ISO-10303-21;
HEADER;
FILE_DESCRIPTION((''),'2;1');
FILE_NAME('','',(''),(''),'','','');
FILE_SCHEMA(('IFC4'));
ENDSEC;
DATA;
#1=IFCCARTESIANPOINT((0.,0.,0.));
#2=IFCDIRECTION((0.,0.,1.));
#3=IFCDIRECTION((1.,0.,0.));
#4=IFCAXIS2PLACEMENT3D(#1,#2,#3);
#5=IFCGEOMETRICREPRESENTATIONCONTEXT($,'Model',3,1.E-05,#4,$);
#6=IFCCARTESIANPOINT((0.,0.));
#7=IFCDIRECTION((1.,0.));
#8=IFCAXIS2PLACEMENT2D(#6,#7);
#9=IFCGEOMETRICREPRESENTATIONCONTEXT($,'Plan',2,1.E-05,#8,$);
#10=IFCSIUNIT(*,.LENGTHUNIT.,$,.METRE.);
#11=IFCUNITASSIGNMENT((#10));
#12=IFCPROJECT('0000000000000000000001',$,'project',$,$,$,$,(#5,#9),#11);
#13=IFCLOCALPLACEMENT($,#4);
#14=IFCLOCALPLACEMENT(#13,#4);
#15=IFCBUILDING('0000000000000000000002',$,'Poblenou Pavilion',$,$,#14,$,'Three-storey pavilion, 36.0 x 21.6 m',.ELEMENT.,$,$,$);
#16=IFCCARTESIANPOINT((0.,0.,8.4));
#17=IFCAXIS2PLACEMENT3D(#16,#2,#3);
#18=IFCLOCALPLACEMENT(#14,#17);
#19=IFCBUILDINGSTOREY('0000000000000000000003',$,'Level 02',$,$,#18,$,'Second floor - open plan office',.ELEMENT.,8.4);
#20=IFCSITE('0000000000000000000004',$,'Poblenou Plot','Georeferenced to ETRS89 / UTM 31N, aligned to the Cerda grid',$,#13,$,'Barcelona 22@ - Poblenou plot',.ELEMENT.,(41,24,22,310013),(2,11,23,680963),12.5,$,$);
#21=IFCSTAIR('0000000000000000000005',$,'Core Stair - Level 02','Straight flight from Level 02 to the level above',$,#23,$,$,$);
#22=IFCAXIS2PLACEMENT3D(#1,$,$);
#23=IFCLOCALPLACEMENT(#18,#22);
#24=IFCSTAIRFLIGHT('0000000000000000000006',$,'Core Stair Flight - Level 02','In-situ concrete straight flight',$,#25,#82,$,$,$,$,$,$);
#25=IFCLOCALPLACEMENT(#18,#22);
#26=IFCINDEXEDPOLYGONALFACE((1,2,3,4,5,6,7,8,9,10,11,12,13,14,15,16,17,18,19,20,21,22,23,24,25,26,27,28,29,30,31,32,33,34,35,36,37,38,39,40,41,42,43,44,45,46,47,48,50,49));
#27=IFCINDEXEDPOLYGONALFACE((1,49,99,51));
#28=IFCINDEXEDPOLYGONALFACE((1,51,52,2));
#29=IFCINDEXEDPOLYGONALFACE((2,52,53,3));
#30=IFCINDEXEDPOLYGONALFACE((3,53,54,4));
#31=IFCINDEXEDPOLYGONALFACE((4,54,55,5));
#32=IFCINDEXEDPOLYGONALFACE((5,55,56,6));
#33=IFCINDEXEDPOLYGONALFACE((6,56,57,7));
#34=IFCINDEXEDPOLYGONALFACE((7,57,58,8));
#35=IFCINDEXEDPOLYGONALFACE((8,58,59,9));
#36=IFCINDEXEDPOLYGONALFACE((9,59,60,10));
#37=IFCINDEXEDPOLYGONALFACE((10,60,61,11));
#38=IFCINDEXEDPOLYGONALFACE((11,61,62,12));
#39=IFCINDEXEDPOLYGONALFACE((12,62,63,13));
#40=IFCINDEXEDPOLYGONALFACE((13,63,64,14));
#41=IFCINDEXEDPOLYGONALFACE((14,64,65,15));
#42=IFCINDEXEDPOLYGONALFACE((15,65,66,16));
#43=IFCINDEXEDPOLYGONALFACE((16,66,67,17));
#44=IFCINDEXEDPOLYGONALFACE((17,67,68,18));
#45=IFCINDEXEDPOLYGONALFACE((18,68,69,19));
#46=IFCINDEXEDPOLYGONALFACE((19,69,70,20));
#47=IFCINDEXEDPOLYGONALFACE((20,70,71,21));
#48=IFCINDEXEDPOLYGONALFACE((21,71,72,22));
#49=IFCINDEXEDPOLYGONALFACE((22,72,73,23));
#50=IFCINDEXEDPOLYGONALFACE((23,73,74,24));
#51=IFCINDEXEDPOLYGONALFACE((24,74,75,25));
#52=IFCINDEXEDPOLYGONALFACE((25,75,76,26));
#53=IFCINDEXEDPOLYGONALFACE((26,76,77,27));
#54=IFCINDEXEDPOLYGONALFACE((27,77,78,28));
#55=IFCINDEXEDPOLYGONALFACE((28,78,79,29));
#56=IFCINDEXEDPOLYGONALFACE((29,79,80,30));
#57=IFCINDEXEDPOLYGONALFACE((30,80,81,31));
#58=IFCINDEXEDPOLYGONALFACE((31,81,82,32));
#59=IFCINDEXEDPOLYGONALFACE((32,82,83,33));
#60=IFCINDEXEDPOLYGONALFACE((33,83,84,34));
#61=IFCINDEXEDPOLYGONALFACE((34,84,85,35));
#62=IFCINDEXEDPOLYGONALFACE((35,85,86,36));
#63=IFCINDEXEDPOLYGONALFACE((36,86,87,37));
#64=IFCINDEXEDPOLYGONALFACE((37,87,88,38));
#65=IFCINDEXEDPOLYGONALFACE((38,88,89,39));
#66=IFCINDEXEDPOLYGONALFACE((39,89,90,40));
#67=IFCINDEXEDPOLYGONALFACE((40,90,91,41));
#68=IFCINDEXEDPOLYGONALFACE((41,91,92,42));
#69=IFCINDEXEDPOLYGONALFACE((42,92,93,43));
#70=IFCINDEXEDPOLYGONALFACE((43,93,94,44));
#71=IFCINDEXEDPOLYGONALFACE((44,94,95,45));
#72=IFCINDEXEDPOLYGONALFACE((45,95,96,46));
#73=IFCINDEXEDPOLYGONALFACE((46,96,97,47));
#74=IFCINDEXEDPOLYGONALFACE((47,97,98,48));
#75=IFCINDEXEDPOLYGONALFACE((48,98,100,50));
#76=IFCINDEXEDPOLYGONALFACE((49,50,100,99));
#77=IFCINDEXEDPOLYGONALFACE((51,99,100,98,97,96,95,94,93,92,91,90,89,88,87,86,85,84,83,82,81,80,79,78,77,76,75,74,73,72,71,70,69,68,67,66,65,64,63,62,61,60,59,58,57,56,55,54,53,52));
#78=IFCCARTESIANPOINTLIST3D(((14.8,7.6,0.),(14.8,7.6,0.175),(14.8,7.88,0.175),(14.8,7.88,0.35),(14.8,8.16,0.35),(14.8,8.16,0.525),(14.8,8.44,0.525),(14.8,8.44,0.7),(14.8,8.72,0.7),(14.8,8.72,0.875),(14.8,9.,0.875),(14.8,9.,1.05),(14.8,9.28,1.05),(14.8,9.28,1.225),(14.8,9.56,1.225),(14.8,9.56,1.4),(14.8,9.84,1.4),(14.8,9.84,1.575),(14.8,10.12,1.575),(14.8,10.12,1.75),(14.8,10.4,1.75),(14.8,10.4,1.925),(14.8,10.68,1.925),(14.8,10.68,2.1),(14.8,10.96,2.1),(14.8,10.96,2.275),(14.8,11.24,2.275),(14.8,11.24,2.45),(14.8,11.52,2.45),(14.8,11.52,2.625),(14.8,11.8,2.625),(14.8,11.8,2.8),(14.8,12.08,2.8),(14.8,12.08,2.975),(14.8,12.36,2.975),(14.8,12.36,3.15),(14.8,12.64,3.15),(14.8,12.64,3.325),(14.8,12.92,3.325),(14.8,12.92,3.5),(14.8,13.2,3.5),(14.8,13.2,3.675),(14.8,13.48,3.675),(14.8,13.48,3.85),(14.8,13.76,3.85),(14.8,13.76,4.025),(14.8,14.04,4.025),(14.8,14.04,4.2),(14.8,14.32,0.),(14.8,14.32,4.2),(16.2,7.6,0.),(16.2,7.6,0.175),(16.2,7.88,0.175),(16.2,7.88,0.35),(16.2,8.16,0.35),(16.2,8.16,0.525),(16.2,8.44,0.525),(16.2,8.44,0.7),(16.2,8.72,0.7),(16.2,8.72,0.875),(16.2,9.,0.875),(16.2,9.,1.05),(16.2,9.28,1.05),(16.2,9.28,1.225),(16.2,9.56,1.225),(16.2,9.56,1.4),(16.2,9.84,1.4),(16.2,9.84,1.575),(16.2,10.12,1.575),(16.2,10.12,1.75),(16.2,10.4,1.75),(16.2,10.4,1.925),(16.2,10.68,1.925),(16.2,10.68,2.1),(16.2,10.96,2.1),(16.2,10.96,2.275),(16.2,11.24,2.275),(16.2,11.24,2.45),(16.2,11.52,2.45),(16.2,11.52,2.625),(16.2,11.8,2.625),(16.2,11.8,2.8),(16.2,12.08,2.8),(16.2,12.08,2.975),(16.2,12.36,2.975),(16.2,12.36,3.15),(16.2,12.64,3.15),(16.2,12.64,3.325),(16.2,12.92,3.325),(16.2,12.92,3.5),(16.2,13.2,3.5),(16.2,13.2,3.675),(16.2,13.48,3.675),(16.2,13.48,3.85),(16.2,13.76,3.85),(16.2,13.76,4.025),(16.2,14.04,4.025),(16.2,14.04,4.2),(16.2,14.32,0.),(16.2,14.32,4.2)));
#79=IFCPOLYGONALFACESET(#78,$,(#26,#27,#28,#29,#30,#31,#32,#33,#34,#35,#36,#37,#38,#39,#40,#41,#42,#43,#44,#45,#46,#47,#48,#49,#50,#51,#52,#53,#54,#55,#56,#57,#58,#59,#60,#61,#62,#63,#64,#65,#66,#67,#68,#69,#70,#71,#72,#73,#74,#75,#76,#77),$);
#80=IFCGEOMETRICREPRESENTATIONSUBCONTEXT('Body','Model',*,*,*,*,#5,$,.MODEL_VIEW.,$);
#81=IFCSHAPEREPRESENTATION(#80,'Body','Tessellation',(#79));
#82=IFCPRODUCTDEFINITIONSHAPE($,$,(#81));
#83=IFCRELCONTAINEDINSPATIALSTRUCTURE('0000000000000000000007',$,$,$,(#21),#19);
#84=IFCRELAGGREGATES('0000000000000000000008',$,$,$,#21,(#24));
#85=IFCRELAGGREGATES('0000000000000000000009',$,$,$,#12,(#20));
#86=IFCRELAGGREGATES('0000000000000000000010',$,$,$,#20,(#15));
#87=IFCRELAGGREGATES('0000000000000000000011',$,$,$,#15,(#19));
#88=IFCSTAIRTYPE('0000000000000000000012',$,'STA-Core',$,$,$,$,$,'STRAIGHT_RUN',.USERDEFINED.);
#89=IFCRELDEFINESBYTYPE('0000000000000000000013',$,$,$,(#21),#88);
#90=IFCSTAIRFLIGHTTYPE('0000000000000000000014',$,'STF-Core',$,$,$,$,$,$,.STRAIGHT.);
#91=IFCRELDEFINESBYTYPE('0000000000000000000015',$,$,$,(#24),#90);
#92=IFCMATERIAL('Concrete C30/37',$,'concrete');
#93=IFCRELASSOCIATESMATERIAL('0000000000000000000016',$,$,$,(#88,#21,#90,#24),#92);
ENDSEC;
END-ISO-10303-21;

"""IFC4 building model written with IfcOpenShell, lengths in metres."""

from ifc_helpers import new_model, si_unit, frame, origin_with_axes, origin_2d_with_axis, place, context, subcontext, project, spatial, line, indexed_curve, outline, extrude, material, type_object, element, aggregate, save


model = new_model("IFC4")

# Units and contexts
model_context = context("Model", 3, precision=1e-05, world=origin_with_axes())
plan_context = context("Plan", 2, precision=1e-05, world=origin_2d_with_axis())
body_context = subcontext(model_context, "Body", "Model", "MODEL_VIEW")
ifc_project = project(units=[si_unit("LENGTHUNIT", "METRE")], contexts=[model_context, plan_context])

# Site, building, storey
site_placement = place(None, origin_with_axes())
site = spatial("IfcSite", under=ifc_project, at=site_placement, Name="Poblenou Plot", Description="Georeferenced to ETRS89 / UTM 31N, aligned to the Cerda grid", LongName="Barcelona 22@ - Poblenou plot", CompositionType="ELEMENT", RefLatitude=(41, 24, 22, 310013), RefLongitude=(2, 11, 23, 680963), RefElevation=12.5)
building_placement = place(site_placement, origin_with_axes())
building = spatial("IfcBuilding", under=site, at=building_placement, Name="Poblenou Pavilion", LongName="Three-storey pavilion, 36.0 x 21.6 m", CompositionType="ELEMENT")
storey_placement = place(building_placement, frame((0.0, 0.0, 8.4), z_axis=(0.0, 0.0, 1.0), x_axis=(1.0, 0.0, 0.0)))
storey = spatial("IfcBuildingStorey", under=building, at=storey_placement, Name="Level 02", LongName="Second floor - open plan office", CompositionType="ELEMENT", Elevation=8.4)

# Stair, stair flight
ifc_material_1 = material(Name="Concrete C30/37", Category="concrete")
stair_type = type_object("IfcStairType", Name="STA-Core", ElementType="STRAIGHT_RUN", PredefinedType="USERDEFINED", material=ifc_material_1)
stair_placement = place(storey_placement, frame((14.8, 7.6, 0.0), z_axis=(0.0, 0.0, 1.0), x_axis=(1.0, 0.0, 0.0)))
stair = element("IfcStair", 1, at=stair_placement, inside=storey, type_object=stair_type, material=ifc_material_1, Name="Core Stair - Level 02", Description="Straight flight from Level 02 to the level above")
stair_flight_type = type_object("IfcStairFlightType", Name="STF-Core", PredefinedType="STRAIGHT", material=ifc_material_1)
stair_flight_placement = place(stair_placement, frame((0.0, 0.0, 0.0), z_axis=(1.0, 0.0, 0.0), x_axis=(0.0, 1.0, 0.0)))
stair_flight = element("IfcStairFlight", 2, at=stair_flight_placement, type_object=stair_flight_type, material=ifc_material_1, Name="Core Stair Flight - Level 02", Description="In-situ concrete straight flight", context=body_context, shape_type="SweptSolid", body=[
    extrude(outline(indexed_curve([(0.0, 0.0), (6.72, 0.0), (6.72, 4.2), (6.44, 4.2), (6.44, 4.025), (6.16, 4.025), (6.16, 3.85), (5.88, 3.85), (5.88, 3.675), (5.6, 3.675), (5.6, 3.5), (5.32, 3.5), (5.32, 3.325), (5.04, 3.325), (5.04, 3.15), (4.76, 3.15), (4.76, 2.975), (4.48, 2.975), (4.48, 2.8), (4.2, 2.8), (4.2, 2.625), (3.92, 2.625), (3.92, 2.45), (3.64, 2.45), (3.64, 2.275), (3.36, 2.275), (3.36, 2.1), (3.08, 2.1), (3.08, 1.925), (2.8, 1.925), (2.8, 1.75), (2.52, 1.75), (2.52, 1.575), (2.24, 1.575), (2.24, 1.4), (1.96, 1.4), (1.96, 1.225), (1.68, 1.225), (1.68, 1.05), (1.4, 1.05), (1.4, 0.875), (1.12, 0.875), (1.12, 0.7), (0.84, 0.7), (0.84, 0.525), (0.56, 0.525), (0.56, 0.35), (0.28, 0.35), (0.28, 0.175), (0.0, 0.175)], segments=[line(1, 2, 3, 4, 5, 6, 7, 8, 9, 10, 11, 12, 13, 14, 15, 16, 17, 18, 19, 20, 21, 22, 23, 24, 25, 26, 27, 28, 29, 30, 31, 32, 33, 34, 35, 36, 37, 38, 39, 40, 41, 42, 43, 44, 45, 46, 47, 48, 49, 50, 1)])), origin_with_axes(), (0.0, 0.0, 1.0), 1.4),
])
aggregate(stair, [stair_flight])

save(model, "model.ifc")
